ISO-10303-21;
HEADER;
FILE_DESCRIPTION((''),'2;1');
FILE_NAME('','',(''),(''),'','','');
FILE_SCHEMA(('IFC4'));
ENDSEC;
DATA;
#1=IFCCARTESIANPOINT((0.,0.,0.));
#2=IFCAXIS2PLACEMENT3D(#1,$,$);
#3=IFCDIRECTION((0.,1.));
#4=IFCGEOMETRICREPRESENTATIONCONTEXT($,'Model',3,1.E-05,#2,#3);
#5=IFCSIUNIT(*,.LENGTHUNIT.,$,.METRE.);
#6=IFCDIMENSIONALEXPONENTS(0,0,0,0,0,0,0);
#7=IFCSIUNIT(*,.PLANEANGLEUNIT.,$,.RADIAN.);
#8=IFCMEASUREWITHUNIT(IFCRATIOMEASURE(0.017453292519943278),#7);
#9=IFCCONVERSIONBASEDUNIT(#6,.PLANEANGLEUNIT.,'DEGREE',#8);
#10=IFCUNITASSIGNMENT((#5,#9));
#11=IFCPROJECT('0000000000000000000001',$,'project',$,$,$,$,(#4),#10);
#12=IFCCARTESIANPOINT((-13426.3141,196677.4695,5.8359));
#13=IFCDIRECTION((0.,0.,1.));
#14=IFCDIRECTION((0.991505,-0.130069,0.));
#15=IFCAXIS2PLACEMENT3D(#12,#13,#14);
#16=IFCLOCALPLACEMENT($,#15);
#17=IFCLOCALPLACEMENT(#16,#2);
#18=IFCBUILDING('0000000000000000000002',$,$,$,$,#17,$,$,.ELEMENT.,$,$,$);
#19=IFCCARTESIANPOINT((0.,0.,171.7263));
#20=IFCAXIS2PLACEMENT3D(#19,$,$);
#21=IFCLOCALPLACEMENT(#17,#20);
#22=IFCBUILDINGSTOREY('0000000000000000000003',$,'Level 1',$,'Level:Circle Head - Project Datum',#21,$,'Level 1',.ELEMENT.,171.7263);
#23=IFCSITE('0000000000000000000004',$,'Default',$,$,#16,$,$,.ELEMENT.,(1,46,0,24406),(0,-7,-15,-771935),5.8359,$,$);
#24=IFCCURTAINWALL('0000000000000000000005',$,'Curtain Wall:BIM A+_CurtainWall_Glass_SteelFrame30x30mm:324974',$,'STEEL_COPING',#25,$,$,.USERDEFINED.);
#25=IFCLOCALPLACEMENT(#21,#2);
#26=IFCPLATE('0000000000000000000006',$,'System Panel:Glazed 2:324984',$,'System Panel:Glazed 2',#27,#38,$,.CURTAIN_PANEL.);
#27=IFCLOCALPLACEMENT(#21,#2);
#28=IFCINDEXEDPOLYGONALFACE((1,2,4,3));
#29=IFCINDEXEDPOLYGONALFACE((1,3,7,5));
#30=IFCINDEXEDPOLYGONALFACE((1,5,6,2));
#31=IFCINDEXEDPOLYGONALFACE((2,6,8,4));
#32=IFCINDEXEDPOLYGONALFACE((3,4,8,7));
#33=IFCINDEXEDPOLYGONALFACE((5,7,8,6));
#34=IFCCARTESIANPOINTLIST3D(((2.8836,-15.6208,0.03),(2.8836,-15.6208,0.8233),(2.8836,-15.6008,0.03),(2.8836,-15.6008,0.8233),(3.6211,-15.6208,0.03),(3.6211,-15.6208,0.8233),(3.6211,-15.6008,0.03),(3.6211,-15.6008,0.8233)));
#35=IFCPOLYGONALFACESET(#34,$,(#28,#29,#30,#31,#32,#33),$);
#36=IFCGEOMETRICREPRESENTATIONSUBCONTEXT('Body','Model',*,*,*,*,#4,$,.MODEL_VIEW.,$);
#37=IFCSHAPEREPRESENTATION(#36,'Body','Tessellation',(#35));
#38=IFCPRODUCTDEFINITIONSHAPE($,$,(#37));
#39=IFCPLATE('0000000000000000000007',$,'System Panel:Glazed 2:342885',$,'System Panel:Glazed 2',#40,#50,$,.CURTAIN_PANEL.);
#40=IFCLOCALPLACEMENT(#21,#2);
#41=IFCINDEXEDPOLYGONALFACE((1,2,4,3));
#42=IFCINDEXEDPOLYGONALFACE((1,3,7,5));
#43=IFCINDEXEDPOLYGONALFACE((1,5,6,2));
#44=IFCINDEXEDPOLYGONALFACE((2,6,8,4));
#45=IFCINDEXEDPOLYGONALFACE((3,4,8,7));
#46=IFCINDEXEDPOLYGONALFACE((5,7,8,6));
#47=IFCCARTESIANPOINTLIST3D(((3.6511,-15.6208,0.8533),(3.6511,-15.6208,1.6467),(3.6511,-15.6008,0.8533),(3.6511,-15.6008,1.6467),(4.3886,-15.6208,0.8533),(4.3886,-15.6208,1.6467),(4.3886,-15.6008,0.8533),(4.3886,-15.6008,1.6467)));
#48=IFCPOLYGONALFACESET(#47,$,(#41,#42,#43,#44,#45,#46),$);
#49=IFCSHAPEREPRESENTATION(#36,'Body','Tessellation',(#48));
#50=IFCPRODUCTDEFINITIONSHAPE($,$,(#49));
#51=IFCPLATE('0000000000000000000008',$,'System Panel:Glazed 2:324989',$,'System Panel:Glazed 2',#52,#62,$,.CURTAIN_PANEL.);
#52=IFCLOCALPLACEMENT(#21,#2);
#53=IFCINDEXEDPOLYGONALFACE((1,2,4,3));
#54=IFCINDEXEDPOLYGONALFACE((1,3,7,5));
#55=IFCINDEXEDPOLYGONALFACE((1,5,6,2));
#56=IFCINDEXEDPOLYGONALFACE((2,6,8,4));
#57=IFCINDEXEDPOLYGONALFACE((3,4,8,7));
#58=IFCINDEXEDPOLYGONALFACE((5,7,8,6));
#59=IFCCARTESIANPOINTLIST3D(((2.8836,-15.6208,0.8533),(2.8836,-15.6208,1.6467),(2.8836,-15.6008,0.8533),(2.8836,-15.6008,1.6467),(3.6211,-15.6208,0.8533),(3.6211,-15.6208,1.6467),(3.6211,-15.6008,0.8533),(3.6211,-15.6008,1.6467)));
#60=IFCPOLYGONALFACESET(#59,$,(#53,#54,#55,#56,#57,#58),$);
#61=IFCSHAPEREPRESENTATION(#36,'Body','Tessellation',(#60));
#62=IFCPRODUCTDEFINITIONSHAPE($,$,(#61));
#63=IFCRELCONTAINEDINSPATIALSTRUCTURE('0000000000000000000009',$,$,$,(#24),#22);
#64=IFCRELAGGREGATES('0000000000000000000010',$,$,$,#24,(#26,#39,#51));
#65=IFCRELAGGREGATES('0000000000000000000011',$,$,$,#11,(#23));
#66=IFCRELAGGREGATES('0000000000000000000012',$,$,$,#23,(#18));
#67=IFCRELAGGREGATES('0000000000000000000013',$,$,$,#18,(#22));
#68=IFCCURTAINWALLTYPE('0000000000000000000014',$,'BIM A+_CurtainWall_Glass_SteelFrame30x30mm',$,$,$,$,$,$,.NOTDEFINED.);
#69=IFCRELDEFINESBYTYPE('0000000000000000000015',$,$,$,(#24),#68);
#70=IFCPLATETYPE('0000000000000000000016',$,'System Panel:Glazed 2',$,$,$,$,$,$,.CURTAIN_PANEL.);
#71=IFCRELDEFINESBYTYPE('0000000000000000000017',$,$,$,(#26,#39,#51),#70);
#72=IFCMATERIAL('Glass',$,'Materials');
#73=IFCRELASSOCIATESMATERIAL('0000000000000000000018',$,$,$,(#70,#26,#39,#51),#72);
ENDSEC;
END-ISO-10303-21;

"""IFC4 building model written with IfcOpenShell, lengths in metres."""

from ifc_helpers import new_model, entity, si_unit, converted_unit, direction, frame, origin, place, context, subcontext, project, spatial, indexed_curve, outline, extrude, source, transform, mapped, material, type_object, type_shapes, element, aggregate, save


model = new_model("IFC4")

# Units and contexts
model_context = context("Model", 3, precision=1e-05, world=origin(), true_north=direction((0.0, 1.0)))
body_context = subcontext(model_context, "Body", "Model", "MODEL_VIEW")
ifc_project = project(units=[si_unit("LENGTHUNIT", "METRE"), converted_unit("PLANEANGLEUNIT", "DEGREE", entity("IfcRatioMeasure", 0.017453292519943278), si_unit("PLANEANGLEUNIT", "RADIAN"), dimensions=[0, 0, 0, 0, 0, 0, 0])], contexts=[model_context])

# Site, building, storey
site_placement = place(None, frame((-13426.3141, 196677.4695, 5.8359), z_axis=(0.0, 0.0, 1.0), x_axis=(0.991505, -0.130069, 0.0)))
site = spatial("IfcSite", under=ifc_project, at=site_placement, Name="Default", CompositionType="ELEMENT", RefLatitude=(1, 46, 0, 24406), RefLongitude=(0, -7, -15, -771935), RefElevation=5.8359)
building_placement = place(site_placement, origin())
building = spatial("IfcBuilding", under=site, at=building_placement, CompositionType="ELEMENT")
storey_placement = place(building_placement, frame((0.0, 0.0, 171.7263)))
storey = spatial("IfcBuildingStorey", under=building, at=storey_placement, Name="Level 1", ObjectType="Level:Circle Head - Project Datum", LongName="Level 1", CompositionType="ELEMENT", Elevation=171.7263)

# Curtain wall
curtain_wall_type_1 = type_object("IfcCurtainWallType", Name="BIM A+_CurtainWall_Glass_SteelFrame30x30mm", PredefinedType="NOTDEFINED")
curtain_wall_1_placement = place(storey_placement, frame((0.0, 0.0, -171.7263)))
curtain_wall_1 = element("IfcCurtainWall", 1, at=curtain_wall_1_placement, inside=storey, type_object=curtain_wall_type_1, Name="Curtain Wall:BIM A+_CurtainWall_Glass_SteelFrame30x30mm:324974", ObjectType="STEEL_COPING", PredefinedType="USERDEFINED")

# Plates
ifc_material_1 = material(Name="Glass", Category="Materials")
plate_type = type_object("IfcPlateType", Name="System Panel:Glazed 2", PredefinedType="CURTAIN_PANEL", material=ifc_material_1)
shared_shape_1 = source(origin(), body_context, "Body", "SweptSolid", [
    extrude(outline(indexed_curve([(-0.01, -0.3688), (0.01, -0.3688), (0.01, 0.3688), (-0.01, 0.3688), (-0.01, -0.3688)], self_intersect=False)), frame((0.0, 0.0, 0.0), z_axis=(0.0, 0.0, 1.0), x_axis=(0.0, 1.0, 0.0)), (0.0, 0.0, 1.0), 0.7933),
])
type_shapes(plate_type, [shared_shape_1])
plate_1_placement = place(curtain_wall_1_placement, frame((3.2523, -15.6108, 171.7563), z_axis=(0.0, 0.0, 1.0), x_axis=(-1.0, 0.0, 0.0)))
plate_1 = element("IfcPlate", 2, at=plate_1_placement, type_object=plate_type, material=ifc_material_1, Name="System Panel:Glazed 2:324984", ObjectType="System Panel:Glazed 2", PredefinedType="CURTAIN_PANEL", context=body_context, shape_type="MappedRepresentation", body=[
    mapped(shared_shape_1, transform((0.0, 0.0, 0.0), scale=1.0)),
])
plate_2_placement = place(curtain_wall_1_placement, frame((4.0198, -15.6108, 172.5796), z_axis=(0.0, 0.0, 1.0), x_axis=(-1.0, 0.0, 0.0)))
plate_2 = element("IfcPlate", 3, at=plate_2_placement, type_object=plate_type, material=ifc_material_1, Name="System Panel:Glazed 2:342885", ObjectType="System Panel:Glazed 2", PredefinedType="CURTAIN_PANEL", context=body_context, shape_type="MappedRepresentation", body=[
    mapped(shared_shape_1, transform((0.0, 0.0, 0.0), scale=1.0)),
])
plate_3_placement = place(curtain_wall_1_placement, frame((3.2523, -15.6108, 172.5796), z_axis=(0.0, 0.0, 1.0), x_axis=(-1.0, 0.0, 0.0)))
plate_3 = element("IfcPlate", 4, at=plate_3_placement, type_object=plate_type, material=ifc_material_1, Name="System Panel:Glazed 2:324989", ObjectType="System Panel:Glazed 2", PredefinedType="CURTAIN_PANEL", context=body_context, shape_type="MappedRepresentation", body=[
    mapped(shared_shape_1, transform((0.0, 0.0, 0.0), scale=1.0)),
])
aggregate(curtain_wall_1, [plate_1, plate_2, plate_3])

save(model, "model.ifc")
